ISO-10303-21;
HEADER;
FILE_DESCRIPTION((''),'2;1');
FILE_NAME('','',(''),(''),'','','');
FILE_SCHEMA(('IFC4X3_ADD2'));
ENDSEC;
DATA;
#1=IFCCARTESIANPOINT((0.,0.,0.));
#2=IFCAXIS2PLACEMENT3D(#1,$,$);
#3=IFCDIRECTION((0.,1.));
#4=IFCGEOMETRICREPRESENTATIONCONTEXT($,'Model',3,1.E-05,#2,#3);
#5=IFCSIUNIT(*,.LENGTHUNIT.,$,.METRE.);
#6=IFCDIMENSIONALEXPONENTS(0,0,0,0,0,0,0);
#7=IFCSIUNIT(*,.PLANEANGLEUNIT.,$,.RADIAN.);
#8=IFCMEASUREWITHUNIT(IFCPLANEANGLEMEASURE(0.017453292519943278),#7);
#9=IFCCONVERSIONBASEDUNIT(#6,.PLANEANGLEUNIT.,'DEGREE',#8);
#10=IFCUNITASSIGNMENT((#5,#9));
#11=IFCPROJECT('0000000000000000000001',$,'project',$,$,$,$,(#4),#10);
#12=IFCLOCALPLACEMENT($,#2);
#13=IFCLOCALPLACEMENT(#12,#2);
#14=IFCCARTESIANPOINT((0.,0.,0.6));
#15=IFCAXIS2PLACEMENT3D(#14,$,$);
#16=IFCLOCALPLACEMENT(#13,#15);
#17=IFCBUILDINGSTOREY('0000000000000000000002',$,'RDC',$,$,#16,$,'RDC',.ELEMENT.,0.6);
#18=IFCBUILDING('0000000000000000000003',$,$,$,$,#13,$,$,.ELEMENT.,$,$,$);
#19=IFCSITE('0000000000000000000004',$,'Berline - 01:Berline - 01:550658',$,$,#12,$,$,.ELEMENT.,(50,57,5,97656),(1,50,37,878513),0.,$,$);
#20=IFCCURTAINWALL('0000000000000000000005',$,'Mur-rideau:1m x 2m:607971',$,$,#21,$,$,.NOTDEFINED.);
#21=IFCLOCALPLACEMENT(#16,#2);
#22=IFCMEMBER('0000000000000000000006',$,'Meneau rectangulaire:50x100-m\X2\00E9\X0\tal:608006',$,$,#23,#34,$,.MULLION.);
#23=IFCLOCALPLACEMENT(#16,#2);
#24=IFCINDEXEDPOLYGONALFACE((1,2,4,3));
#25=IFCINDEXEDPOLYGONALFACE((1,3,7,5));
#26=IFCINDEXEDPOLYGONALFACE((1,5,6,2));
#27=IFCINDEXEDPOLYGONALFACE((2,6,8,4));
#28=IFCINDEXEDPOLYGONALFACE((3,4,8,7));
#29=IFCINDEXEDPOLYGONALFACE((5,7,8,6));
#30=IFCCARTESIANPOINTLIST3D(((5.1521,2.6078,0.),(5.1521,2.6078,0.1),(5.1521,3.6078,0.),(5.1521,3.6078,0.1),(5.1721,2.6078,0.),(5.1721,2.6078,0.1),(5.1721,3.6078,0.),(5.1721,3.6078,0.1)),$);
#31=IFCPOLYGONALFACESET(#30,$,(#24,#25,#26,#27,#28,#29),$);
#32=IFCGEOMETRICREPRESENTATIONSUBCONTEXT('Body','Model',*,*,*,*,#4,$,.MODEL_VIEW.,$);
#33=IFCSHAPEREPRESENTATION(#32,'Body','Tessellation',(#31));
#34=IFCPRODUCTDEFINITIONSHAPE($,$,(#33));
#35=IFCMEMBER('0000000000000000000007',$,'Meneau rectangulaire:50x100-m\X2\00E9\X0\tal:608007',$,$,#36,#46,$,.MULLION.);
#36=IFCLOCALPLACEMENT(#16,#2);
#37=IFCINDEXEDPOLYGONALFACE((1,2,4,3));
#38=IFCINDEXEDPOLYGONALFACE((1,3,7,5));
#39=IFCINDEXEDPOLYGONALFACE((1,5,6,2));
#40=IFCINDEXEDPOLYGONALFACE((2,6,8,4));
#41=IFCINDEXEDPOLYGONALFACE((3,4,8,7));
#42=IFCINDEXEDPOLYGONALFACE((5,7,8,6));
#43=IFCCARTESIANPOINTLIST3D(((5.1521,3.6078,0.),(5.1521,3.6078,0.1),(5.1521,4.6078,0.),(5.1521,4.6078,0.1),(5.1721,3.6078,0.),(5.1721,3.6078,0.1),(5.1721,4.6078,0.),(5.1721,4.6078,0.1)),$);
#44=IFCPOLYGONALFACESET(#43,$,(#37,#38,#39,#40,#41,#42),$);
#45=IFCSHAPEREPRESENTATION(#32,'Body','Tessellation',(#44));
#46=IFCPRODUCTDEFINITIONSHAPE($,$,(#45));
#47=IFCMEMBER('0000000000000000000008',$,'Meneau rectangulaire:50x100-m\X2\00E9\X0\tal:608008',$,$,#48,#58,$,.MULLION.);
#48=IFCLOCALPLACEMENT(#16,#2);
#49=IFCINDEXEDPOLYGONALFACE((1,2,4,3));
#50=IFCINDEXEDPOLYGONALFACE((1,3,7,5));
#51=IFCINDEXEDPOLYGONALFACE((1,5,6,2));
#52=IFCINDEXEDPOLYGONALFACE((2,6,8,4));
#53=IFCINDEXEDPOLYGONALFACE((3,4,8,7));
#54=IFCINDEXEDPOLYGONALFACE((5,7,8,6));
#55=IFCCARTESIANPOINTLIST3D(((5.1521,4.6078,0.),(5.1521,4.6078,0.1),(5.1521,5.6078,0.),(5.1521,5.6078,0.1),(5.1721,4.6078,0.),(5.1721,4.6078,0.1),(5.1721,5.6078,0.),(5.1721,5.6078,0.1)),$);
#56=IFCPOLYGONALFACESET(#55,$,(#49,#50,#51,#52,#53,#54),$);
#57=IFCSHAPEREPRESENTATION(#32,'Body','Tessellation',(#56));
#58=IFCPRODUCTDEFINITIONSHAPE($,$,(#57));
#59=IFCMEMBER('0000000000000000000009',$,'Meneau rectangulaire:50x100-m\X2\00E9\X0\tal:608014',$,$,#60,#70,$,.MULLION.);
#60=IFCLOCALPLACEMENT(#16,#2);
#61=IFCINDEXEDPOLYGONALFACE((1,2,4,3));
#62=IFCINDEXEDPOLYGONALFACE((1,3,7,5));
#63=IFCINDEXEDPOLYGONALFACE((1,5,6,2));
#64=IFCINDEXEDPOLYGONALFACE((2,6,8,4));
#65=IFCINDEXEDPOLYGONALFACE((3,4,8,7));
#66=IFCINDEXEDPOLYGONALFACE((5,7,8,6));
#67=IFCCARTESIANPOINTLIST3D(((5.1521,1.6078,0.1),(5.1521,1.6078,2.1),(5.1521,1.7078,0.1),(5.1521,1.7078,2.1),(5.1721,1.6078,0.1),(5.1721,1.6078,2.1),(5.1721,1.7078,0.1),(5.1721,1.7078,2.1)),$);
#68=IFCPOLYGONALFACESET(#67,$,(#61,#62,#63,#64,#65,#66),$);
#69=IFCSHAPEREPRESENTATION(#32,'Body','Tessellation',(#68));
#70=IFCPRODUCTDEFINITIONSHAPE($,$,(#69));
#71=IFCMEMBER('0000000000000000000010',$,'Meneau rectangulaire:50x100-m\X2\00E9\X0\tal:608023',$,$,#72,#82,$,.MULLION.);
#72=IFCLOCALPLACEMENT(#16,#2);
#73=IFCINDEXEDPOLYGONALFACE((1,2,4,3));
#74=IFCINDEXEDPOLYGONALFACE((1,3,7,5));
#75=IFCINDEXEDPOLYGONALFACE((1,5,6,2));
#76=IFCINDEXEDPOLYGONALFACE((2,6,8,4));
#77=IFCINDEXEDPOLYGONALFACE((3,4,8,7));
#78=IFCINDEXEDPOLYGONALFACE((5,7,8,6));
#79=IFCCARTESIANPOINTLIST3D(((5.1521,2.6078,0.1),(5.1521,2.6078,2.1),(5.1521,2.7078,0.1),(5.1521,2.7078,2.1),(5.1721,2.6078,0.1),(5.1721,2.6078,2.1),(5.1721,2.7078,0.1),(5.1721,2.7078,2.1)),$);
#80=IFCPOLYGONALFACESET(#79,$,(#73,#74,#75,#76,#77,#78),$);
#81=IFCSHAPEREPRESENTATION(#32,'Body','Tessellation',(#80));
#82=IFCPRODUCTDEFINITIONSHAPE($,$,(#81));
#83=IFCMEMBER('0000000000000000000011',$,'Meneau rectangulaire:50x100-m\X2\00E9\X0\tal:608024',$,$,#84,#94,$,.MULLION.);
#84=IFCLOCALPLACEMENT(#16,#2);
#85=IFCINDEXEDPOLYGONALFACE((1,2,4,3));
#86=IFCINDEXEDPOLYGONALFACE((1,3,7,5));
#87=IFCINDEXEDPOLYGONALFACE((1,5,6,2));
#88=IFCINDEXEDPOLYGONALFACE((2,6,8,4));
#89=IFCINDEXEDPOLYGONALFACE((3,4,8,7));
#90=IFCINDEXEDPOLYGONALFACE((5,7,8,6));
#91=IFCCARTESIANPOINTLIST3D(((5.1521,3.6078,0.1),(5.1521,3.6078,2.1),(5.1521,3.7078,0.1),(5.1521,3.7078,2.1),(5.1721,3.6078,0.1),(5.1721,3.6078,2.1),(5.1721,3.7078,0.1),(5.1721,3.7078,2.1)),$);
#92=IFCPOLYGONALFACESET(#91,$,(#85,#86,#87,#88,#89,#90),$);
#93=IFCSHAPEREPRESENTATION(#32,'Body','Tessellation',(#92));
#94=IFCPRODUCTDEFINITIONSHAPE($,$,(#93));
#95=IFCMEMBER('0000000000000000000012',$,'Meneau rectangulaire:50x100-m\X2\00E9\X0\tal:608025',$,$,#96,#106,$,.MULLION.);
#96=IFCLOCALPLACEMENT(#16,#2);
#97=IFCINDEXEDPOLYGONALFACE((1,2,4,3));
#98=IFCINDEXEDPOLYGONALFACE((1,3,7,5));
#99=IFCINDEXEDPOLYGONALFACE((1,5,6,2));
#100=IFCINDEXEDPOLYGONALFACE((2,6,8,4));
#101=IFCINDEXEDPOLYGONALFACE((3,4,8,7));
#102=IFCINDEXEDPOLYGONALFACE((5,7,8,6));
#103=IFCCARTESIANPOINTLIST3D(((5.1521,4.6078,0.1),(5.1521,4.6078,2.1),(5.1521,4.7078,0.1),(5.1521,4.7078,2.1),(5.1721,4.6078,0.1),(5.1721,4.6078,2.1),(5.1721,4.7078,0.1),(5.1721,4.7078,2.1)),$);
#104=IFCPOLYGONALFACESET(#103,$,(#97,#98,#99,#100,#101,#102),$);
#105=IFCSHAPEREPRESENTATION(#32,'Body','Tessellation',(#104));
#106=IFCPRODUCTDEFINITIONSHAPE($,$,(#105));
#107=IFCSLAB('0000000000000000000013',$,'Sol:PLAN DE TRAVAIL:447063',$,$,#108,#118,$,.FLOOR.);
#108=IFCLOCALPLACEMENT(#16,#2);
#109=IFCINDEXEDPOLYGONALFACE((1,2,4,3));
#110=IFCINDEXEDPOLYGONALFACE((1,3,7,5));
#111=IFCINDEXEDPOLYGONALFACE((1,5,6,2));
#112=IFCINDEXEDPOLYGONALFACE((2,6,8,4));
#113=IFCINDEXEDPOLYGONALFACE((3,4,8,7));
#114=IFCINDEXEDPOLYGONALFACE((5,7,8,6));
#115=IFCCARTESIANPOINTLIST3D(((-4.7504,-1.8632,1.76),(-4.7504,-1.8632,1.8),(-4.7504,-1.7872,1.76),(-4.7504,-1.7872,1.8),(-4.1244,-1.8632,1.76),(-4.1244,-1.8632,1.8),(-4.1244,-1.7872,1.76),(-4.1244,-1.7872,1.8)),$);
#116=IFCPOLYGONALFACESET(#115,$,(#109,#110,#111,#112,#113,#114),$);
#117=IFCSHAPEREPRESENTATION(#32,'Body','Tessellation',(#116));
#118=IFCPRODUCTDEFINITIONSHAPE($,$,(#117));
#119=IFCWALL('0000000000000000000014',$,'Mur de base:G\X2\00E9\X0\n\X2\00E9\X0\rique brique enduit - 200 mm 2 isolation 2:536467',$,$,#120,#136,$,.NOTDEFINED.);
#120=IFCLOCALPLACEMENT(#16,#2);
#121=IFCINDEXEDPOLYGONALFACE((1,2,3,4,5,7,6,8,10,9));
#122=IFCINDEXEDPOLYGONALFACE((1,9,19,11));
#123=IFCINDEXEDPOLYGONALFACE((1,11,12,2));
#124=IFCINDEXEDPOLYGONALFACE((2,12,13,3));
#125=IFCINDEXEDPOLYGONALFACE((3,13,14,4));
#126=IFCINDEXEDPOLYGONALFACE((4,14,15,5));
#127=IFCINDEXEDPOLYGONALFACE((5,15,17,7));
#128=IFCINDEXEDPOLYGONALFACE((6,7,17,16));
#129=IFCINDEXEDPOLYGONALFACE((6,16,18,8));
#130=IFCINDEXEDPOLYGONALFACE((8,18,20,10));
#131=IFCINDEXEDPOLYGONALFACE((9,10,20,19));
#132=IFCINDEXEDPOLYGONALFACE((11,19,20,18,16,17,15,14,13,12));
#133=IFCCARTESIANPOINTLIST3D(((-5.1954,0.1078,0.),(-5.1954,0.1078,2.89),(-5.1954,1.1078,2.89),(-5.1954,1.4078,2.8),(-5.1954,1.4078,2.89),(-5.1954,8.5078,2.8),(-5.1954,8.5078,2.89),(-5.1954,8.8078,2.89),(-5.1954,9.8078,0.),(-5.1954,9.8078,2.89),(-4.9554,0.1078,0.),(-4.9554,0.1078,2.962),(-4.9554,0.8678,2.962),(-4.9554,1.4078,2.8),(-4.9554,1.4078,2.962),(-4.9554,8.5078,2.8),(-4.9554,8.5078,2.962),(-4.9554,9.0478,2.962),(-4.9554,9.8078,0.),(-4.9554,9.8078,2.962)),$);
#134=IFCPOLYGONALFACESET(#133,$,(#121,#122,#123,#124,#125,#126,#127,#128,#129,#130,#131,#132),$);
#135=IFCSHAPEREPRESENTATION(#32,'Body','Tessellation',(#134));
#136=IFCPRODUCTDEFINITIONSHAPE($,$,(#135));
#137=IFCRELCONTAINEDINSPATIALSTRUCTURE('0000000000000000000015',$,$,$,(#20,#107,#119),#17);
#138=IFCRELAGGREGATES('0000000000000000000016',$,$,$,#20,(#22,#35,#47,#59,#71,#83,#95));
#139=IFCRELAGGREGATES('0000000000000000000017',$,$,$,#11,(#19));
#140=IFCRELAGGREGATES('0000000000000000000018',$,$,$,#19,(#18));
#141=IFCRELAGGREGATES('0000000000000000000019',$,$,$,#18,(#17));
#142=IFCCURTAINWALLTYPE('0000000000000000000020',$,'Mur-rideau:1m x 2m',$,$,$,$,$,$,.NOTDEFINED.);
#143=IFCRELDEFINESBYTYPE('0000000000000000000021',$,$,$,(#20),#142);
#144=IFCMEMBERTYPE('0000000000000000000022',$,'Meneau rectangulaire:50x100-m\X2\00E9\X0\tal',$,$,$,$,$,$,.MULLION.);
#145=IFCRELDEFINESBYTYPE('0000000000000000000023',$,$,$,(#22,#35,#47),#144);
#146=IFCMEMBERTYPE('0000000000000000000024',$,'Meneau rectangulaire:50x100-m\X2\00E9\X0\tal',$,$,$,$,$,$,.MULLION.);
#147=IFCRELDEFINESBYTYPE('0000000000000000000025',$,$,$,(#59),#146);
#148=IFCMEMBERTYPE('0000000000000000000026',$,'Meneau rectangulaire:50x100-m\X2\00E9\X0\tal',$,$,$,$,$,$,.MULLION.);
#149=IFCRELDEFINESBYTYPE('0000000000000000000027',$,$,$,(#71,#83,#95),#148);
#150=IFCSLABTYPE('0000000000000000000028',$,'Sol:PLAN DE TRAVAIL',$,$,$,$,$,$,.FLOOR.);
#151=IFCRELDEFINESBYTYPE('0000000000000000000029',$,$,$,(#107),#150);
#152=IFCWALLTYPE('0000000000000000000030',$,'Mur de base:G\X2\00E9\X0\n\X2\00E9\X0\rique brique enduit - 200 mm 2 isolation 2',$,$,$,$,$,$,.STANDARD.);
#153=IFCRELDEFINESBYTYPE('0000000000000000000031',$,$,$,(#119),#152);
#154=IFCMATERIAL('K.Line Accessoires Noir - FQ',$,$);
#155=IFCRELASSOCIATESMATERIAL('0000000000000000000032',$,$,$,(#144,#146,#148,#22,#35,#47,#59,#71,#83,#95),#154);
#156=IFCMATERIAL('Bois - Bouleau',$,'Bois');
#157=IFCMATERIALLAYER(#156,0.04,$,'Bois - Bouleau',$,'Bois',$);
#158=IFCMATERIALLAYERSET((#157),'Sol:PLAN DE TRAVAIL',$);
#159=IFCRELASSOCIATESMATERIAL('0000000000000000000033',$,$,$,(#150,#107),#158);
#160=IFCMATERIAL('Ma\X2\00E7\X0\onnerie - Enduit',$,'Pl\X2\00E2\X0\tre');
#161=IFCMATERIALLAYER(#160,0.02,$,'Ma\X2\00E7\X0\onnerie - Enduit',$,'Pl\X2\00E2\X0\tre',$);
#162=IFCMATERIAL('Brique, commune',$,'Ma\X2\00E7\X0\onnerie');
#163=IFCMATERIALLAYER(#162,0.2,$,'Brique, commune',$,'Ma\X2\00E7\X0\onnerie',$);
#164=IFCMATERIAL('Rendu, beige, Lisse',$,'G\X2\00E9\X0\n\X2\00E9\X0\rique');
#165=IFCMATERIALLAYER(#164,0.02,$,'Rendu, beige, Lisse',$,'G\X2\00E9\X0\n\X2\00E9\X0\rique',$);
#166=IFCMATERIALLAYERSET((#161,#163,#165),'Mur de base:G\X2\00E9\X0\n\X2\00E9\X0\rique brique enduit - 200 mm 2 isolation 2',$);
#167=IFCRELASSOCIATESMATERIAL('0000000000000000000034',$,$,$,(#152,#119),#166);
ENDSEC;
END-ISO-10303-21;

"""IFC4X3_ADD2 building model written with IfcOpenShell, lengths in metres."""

from ifc_helpers import new_model, entity, si_unit, converted_unit, direction, frame, frame_2d, origin, origin_2d_with_axis, place, context, subcontext, project, spatial, polyline, rectangle, extrude, clip, bounded_halfspace, source, transform, mapped, material, layer, layer_set, layer_usage, material_profile, profile_set, profile_usage, type_object, type_shapes, element, aggregate, save


model = new_model("IFC4X3_ADD2")

# Units and contexts
model_context = context("Model", 3, precision=1e-05, world=origin(), true_north=direction((0.0, 1.0)))
body_context = subcontext(model_context, "Body", "Model", "MODEL_VIEW")
ifc_project = project(units=[si_unit("LENGTHUNIT", "METRE"), converted_unit("PLANEANGLEUNIT", "DEGREE", entity("IfcPlaneAngleMeasure", 0.017453292519943278), si_unit("PLANEANGLEUNIT", "RADIAN"), dimensions=[0, 0, 0, 0, 0, 0, 0])], contexts=[model_context])

# Site, building, storey
site_placement = place(None, origin())
site = spatial("IfcSite", under=ifc_project, at=site_placement, Name="Berline - 01:Berline - 01:550658", CompositionType="ELEMENT", RefLatitude=(50, 57, 5, 97656), RefLongitude=(1, 50, 37, 878513), RefElevation=0.0)
building_placement = place(site_placement, origin())
building = spatial("IfcBuilding", under=site, at=building_placement, CompositionType="ELEMENT")
storey_placement = place(building_placement, frame((0.0, 0.0, 0.6)))
storey = spatial("IfcBuildingStorey", under=building, at=storey_placement, Name="RDC", LongName="RDC", CompositionType="ELEMENT", Elevation=0.6)

# Shared definitions
ifc_material_1 = material(Name="Bois - Bouleau", Category="Bois")

# Curtain wall, members
curtain_wall_type = type_object("IfcCurtainWallType", Name="Mur-rideau:1m x 2m", PredefinedType="NOTDEFINED")
curtain_wall_placement = place(storey_placement, frame((0.0, 0.0, -0.6)))
curtain_wall = element("IfcCurtainWall", 1, at=curtain_wall_placement, inside=storey, type_object=curtain_wall_type, Name="Mur-rideau:1m x 2m:607971", PredefinedType="NOTDEFINED")
ifc_material_2 = material(Name="K.Line Accessoires Noir - FQ")
ifc_material_profile_1 = material_profile(ifc_material_2, rectangle(XDim=0.1, YDim=0.02, at=origin_2d_with_axis()), Name="50x100-métal")
ifc_profile_set_1 = profile_set([ifc_material_profile_1], Name="50x100-métal")
ifc_profile_usage_1 = profile_usage(ifc_profile_set_1)
member_type_1 = type_object("IfcMemberType", Name="Meneau rectangulaire:50x100-métal", PredefinedType="MULLION", material=ifc_profile_set_1)
shared_shape_1 = source(origin(), body_context, "Body", "SweptSolid", [
    extrude(rectangle(XDim=0.1, YDim=0.02, at=origin_2d_with_axis()), frame((-0.05, -0.01, -1.0)), (0.0, 0.0, 1.0), 1.0),
])
type_shapes(member_type_1, [shared_shape_1])
member_1_placement = place(curtain_wall_placement, frame((5.1721, 2.6078, 0.6), z_axis=(0.0, -1.0, 0.0), x_axis=(0.0, 0.0, -1.0)))
member_1 = element("IfcMember", 2, at=member_1_placement, type_object=member_type_1, material=ifc_profile_usage_1, Name="Meneau rectangulaire:50x100-métal:608006", PredefinedType="MULLION", context=body_context, shape_type="MappedRepresentation", body=[
    mapped(shared_shape_1, transform((0.0, 0.0, 0.0), scale=1.0)),
])
member_2_placement = place(curtain_wall_placement, frame((5.1721, 3.6078, 0.6), z_axis=(0.0, -1.0, 0.0), x_axis=(0.0, 0.0, -1.0)))
member_2 = element("IfcMember", 3, at=member_2_placement, type_object=member_type_1, material=ifc_profile_usage_1, Name="Meneau rectangulaire:50x100-métal:608007", PredefinedType="MULLION", context=body_context, shape_type="MappedRepresentation", body=[
    mapped(shared_shape_1, transform((0.0, 0.0, 0.0), scale=1.0)),
])
member_3_placement = place(curtain_wall_placement, frame((5.1721, 4.6078, 0.6), z_axis=(0.0, -1.0, 0.0), x_axis=(0.0, 0.0, -1.0)))
member_3 = element("IfcMember", 4, at=member_3_placement, type_object=member_type_1, material=ifc_profile_usage_1, Name="Meneau rectangulaire:50x100-métal:608008", PredefinedType="MULLION", context=body_context, shape_type="MappedRepresentation", body=[
    mapped(shared_shape_1, transform((0.0, 0.0, 0.0), scale=1.0)),
])
member_type_2 = type_object("IfcMemberType", Name="Meneau rectangulaire:50x100-métal", PredefinedType="MULLION", material=ifc_profile_set_1)
shared_shape_2 = source(origin(), body_context, "Body", "SweptSolid", [
    extrude(rectangle(XDim=0.1, YDim=0.02, at=origin_2d_with_axis()), frame((-0.05, -0.01, -2.0)), (0.0, 0.0, 1.0), 2.0),
])
type_shapes(member_type_2, [shared_shape_2])
member_4_placement = place(curtain_wall_placement, frame((5.1721, 1.6078, 2.7), z_axis=(0.0, 0.0, 1.0), x_axis=(0.0, -1.0, 0.0)))
member_4 = element("IfcMember", 5, at=member_4_placement, type_object=member_type_2, material=ifc_profile_usage_1, Name="Meneau rectangulaire:50x100-métal:608014", PredefinedType="MULLION", context=body_context, shape_type="MappedRepresentation", body=[
    mapped(shared_shape_2, transform((0.0, 0.0, 0.0), scale=1.0)),
])
member_type_3 = type_object("IfcMemberType", Name="Meneau rectangulaire:50x100-métal", PredefinedType="MULLION", material=ifc_profile_set_1)
shared_shape_3 = source(origin(), body_context, "Body", "SweptSolid", [
    extrude(rectangle(XDim=0.02, YDim=0.1, at=origin_2d_with_axis()), frame((0.05, -0.01, -2.0), z_axis=(0.0, 0.0, 1.0), x_axis=(0.0, 1.0, 0.0)), (0.0, 0.0, 1.0), 2.0),
])
type_shapes(member_type_3, [shared_shape_3])
member_5_placement = place(curtain_wall_placement, frame((5.1721, 2.6078, 0.7), z_axis=(0.0, 0.0, -1.0), x_axis=(0.0, 1.0, 0.0)))
member_5 = element("IfcMember", 6, at=member_5_placement, type_object=member_type_3, material=ifc_profile_usage_1, Name="Meneau rectangulaire:50x100-métal:608023", PredefinedType="MULLION", context=body_context, shape_type="MappedRepresentation", body=[
    mapped(shared_shape_3, transform((0.0, 0.0, 0.0), scale=1.0)),
])
member_6_placement = place(curtain_wall_placement, frame((5.1721, 3.6078, 0.7), z_axis=(0.0, 0.0, -1.0), x_axis=(0.0, 1.0, 0.0)))
member_6 = element("IfcMember", 7, at=member_6_placement, type_object=member_type_3, material=ifc_profile_usage_1, Name="Meneau rectangulaire:50x100-métal:608024", PredefinedType="MULLION", context=body_context, shape_type="MappedRepresentation", body=[
    mapped(shared_shape_3, transform((0.0, 0.0, 0.0), scale=1.0)),
])
member_7_placement = place(curtain_wall_placement, frame((5.1721, 4.6078, 0.7), z_axis=(0.0, 0.0, -1.0), x_axis=(0.0, 1.0, 0.0)))
member_7 = element("IfcMember", 8, at=member_7_placement, type_object=member_type_3, material=ifc_profile_usage_1, Name="Meneau rectangulaire:50x100-métal:608025", PredefinedType="MULLION", context=body_context, shape_type="MappedRepresentation", body=[
    mapped(shared_shape_3, transform((0.0, 0.0, 0.0), scale=1.0)),
])

# Slab
ifc_layer_1 = layer(ifc_material_1, 0.04, Name="Bois - Bouleau", Category="Bois")
ifc_layer_set_1 = layer_set([ifc_layer_1], Name="Sol:PLAN DE TRAVAIL")
ifc_layer_usage_1 = layer_usage(ifc_layer_set_1, "AXIS3", "POSITIVE", 0.0)
slab_type_1 = type_object("IfcSlabType", Name="Sol:PLAN DE TRAVAIL", PredefinedType="FLOOR", material=ifc_layer_set_1)
slab_1_placement = place(storey_placement, origin())
element("IfcSlab", 9, at=slab_1_placement, inside=storey, type_object=slab_type_1, material=ifc_layer_usage_1, Name="Sol:PLAN DE TRAVAIL:447063", PredefinedType="FLOOR", context=body_context, shape_type="SweptSolid", body=[
    extrude(rectangle(XDim=0.076, YDim=0.626, at=origin_2d_with_axis()), frame((-4.4374, -1.8252, 1.8), z_axis=(0.0, 0.0, -1.0), x_axis=(0.0, 1.0, 0.0)), (0.0, 0.0, 1.0), 0.04),
])

aggregate(curtain_wall, [member_1, member_2, member_3, member_4, member_5, member_6, member_7])

# Wall
ifc_material_3 = material(Name="Maçonnerie - Enduit", Category="Plâtre")
ifc_layer_2 = layer(ifc_material_3, 0.02, Name="Maçonnerie - Enduit", Category="Plâtre")
ifc_material_4 = material(Name="Brique, commune", Category="Maçonnerie")
ifc_layer_3 = layer(ifc_material_4, 0.2, Name="Brique, commune", Category="Maçonnerie")
ifc_material_5 = material(Name="Rendu, beige, Lisse", Category="Générique")
ifc_layer_4 = layer(ifc_material_5, 0.02, Name="Rendu, beige, Lisse", Category="Générique")
ifc_layer_set_2 = layer_set([ifc_layer_2, ifc_layer_3, ifc_layer_4], Name="Mur de base:Générique brique enduit - 200 mm 2 isolation 2")
wall_type = type_object("IfcWallType", Name="Mur de base:Générique brique enduit - 200 mm 2 isolation 2", PredefinedType="STANDARD", material=ifc_layer_set_2)
wall_placement = place(storey_placement, frame((-5.0754, 0.1078, 0.0), z_axis=(0.0, 0.0, 1.0), x_axis=(0.0, 1.0, 0.0)))
element("IfcWall", 10, at=wall_placement, inside=storey, type_object=wall_type, material=ifc_layer_set_2, Name="Mur de base:Générique brique enduit - 200 mm 2 isolation 2:536467", PredefinedType="NOTDEFINED", context=body_context, shape_type="Clipping", body=[
    clip(clip(clip(clip(clip(extrude(rectangle(XDim=9.7, YDim=0.24, at=frame_2d((4.85, 0.0), x_axis=(-1.0, 0.0))), origin(), (0.0, 0.0, 1.0), 2.962), bounded_halfspace(frame((0.76, -0.12, 2.962), z_axis=(0.287361, 0.0, 0.957822), x_axis=(0.0, 1.0, 0.0)), False, frame((0.76, -0.12, 2.962)), polyline([(0.0, 0.0), (0.54, 0.0), (0.54, 0.24), (0.24, 0.24), (0.0, 0.0)]))), bounded_halfspace(frame((1.3, -0.12, 2.962), z_axis=(0.0, 0.287361, 0.957822), x_axis=(-1.0, 0.0, 0.0)), False, frame((1.3, -0.12, 2.962)), polyline([(0.0, 0.0), (7.1, 0.0), (7.1, 0.192), (7.1, 0.24), (0.0, 0.24), (0.0, 0.192), (0.0, 0.0)]))), bounded_halfspace(frame((8.4, -0.12, 2.8), z_axis=(-0.287361, 0.0, 0.957822), x_axis=(0.0, -1.0, 0.0)), False, frame((8.4, -0.12, 2.8)), polyline([(0.0, 0.0), (0.54, 0.0), (0.3, 0.24), (0.0, 0.24), (0.0, 0.0)]))), bounded_halfspace(frame((0.0, -0.12, 2.962), z_axis=(0.0, 0.287361, 0.957822), x_axis=(-1.0, 0.0, 0.0)), False, frame((0.0, -0.12, 2.962)), polyline([(0.0, 0.0), (0.76, 0.0), (1.0, 0.24), (0.0, 0.24), (0.0, 0.0)]))), bounded_halfspace(frame((8.94, -0.12, 2.962), z_axis=(0.0, 0.287361, 0.957822), x_axis=(-1.0, 0.0, 0.0)), False, frame((8.94, -0.12, 2.962)), polyline([(0.0, 0.0), (0.76, 0.0), (0.76, 0.24), (-0.24, 0.24), (0.0, 0.0)]))),
])

save(model, "model.ifc")
